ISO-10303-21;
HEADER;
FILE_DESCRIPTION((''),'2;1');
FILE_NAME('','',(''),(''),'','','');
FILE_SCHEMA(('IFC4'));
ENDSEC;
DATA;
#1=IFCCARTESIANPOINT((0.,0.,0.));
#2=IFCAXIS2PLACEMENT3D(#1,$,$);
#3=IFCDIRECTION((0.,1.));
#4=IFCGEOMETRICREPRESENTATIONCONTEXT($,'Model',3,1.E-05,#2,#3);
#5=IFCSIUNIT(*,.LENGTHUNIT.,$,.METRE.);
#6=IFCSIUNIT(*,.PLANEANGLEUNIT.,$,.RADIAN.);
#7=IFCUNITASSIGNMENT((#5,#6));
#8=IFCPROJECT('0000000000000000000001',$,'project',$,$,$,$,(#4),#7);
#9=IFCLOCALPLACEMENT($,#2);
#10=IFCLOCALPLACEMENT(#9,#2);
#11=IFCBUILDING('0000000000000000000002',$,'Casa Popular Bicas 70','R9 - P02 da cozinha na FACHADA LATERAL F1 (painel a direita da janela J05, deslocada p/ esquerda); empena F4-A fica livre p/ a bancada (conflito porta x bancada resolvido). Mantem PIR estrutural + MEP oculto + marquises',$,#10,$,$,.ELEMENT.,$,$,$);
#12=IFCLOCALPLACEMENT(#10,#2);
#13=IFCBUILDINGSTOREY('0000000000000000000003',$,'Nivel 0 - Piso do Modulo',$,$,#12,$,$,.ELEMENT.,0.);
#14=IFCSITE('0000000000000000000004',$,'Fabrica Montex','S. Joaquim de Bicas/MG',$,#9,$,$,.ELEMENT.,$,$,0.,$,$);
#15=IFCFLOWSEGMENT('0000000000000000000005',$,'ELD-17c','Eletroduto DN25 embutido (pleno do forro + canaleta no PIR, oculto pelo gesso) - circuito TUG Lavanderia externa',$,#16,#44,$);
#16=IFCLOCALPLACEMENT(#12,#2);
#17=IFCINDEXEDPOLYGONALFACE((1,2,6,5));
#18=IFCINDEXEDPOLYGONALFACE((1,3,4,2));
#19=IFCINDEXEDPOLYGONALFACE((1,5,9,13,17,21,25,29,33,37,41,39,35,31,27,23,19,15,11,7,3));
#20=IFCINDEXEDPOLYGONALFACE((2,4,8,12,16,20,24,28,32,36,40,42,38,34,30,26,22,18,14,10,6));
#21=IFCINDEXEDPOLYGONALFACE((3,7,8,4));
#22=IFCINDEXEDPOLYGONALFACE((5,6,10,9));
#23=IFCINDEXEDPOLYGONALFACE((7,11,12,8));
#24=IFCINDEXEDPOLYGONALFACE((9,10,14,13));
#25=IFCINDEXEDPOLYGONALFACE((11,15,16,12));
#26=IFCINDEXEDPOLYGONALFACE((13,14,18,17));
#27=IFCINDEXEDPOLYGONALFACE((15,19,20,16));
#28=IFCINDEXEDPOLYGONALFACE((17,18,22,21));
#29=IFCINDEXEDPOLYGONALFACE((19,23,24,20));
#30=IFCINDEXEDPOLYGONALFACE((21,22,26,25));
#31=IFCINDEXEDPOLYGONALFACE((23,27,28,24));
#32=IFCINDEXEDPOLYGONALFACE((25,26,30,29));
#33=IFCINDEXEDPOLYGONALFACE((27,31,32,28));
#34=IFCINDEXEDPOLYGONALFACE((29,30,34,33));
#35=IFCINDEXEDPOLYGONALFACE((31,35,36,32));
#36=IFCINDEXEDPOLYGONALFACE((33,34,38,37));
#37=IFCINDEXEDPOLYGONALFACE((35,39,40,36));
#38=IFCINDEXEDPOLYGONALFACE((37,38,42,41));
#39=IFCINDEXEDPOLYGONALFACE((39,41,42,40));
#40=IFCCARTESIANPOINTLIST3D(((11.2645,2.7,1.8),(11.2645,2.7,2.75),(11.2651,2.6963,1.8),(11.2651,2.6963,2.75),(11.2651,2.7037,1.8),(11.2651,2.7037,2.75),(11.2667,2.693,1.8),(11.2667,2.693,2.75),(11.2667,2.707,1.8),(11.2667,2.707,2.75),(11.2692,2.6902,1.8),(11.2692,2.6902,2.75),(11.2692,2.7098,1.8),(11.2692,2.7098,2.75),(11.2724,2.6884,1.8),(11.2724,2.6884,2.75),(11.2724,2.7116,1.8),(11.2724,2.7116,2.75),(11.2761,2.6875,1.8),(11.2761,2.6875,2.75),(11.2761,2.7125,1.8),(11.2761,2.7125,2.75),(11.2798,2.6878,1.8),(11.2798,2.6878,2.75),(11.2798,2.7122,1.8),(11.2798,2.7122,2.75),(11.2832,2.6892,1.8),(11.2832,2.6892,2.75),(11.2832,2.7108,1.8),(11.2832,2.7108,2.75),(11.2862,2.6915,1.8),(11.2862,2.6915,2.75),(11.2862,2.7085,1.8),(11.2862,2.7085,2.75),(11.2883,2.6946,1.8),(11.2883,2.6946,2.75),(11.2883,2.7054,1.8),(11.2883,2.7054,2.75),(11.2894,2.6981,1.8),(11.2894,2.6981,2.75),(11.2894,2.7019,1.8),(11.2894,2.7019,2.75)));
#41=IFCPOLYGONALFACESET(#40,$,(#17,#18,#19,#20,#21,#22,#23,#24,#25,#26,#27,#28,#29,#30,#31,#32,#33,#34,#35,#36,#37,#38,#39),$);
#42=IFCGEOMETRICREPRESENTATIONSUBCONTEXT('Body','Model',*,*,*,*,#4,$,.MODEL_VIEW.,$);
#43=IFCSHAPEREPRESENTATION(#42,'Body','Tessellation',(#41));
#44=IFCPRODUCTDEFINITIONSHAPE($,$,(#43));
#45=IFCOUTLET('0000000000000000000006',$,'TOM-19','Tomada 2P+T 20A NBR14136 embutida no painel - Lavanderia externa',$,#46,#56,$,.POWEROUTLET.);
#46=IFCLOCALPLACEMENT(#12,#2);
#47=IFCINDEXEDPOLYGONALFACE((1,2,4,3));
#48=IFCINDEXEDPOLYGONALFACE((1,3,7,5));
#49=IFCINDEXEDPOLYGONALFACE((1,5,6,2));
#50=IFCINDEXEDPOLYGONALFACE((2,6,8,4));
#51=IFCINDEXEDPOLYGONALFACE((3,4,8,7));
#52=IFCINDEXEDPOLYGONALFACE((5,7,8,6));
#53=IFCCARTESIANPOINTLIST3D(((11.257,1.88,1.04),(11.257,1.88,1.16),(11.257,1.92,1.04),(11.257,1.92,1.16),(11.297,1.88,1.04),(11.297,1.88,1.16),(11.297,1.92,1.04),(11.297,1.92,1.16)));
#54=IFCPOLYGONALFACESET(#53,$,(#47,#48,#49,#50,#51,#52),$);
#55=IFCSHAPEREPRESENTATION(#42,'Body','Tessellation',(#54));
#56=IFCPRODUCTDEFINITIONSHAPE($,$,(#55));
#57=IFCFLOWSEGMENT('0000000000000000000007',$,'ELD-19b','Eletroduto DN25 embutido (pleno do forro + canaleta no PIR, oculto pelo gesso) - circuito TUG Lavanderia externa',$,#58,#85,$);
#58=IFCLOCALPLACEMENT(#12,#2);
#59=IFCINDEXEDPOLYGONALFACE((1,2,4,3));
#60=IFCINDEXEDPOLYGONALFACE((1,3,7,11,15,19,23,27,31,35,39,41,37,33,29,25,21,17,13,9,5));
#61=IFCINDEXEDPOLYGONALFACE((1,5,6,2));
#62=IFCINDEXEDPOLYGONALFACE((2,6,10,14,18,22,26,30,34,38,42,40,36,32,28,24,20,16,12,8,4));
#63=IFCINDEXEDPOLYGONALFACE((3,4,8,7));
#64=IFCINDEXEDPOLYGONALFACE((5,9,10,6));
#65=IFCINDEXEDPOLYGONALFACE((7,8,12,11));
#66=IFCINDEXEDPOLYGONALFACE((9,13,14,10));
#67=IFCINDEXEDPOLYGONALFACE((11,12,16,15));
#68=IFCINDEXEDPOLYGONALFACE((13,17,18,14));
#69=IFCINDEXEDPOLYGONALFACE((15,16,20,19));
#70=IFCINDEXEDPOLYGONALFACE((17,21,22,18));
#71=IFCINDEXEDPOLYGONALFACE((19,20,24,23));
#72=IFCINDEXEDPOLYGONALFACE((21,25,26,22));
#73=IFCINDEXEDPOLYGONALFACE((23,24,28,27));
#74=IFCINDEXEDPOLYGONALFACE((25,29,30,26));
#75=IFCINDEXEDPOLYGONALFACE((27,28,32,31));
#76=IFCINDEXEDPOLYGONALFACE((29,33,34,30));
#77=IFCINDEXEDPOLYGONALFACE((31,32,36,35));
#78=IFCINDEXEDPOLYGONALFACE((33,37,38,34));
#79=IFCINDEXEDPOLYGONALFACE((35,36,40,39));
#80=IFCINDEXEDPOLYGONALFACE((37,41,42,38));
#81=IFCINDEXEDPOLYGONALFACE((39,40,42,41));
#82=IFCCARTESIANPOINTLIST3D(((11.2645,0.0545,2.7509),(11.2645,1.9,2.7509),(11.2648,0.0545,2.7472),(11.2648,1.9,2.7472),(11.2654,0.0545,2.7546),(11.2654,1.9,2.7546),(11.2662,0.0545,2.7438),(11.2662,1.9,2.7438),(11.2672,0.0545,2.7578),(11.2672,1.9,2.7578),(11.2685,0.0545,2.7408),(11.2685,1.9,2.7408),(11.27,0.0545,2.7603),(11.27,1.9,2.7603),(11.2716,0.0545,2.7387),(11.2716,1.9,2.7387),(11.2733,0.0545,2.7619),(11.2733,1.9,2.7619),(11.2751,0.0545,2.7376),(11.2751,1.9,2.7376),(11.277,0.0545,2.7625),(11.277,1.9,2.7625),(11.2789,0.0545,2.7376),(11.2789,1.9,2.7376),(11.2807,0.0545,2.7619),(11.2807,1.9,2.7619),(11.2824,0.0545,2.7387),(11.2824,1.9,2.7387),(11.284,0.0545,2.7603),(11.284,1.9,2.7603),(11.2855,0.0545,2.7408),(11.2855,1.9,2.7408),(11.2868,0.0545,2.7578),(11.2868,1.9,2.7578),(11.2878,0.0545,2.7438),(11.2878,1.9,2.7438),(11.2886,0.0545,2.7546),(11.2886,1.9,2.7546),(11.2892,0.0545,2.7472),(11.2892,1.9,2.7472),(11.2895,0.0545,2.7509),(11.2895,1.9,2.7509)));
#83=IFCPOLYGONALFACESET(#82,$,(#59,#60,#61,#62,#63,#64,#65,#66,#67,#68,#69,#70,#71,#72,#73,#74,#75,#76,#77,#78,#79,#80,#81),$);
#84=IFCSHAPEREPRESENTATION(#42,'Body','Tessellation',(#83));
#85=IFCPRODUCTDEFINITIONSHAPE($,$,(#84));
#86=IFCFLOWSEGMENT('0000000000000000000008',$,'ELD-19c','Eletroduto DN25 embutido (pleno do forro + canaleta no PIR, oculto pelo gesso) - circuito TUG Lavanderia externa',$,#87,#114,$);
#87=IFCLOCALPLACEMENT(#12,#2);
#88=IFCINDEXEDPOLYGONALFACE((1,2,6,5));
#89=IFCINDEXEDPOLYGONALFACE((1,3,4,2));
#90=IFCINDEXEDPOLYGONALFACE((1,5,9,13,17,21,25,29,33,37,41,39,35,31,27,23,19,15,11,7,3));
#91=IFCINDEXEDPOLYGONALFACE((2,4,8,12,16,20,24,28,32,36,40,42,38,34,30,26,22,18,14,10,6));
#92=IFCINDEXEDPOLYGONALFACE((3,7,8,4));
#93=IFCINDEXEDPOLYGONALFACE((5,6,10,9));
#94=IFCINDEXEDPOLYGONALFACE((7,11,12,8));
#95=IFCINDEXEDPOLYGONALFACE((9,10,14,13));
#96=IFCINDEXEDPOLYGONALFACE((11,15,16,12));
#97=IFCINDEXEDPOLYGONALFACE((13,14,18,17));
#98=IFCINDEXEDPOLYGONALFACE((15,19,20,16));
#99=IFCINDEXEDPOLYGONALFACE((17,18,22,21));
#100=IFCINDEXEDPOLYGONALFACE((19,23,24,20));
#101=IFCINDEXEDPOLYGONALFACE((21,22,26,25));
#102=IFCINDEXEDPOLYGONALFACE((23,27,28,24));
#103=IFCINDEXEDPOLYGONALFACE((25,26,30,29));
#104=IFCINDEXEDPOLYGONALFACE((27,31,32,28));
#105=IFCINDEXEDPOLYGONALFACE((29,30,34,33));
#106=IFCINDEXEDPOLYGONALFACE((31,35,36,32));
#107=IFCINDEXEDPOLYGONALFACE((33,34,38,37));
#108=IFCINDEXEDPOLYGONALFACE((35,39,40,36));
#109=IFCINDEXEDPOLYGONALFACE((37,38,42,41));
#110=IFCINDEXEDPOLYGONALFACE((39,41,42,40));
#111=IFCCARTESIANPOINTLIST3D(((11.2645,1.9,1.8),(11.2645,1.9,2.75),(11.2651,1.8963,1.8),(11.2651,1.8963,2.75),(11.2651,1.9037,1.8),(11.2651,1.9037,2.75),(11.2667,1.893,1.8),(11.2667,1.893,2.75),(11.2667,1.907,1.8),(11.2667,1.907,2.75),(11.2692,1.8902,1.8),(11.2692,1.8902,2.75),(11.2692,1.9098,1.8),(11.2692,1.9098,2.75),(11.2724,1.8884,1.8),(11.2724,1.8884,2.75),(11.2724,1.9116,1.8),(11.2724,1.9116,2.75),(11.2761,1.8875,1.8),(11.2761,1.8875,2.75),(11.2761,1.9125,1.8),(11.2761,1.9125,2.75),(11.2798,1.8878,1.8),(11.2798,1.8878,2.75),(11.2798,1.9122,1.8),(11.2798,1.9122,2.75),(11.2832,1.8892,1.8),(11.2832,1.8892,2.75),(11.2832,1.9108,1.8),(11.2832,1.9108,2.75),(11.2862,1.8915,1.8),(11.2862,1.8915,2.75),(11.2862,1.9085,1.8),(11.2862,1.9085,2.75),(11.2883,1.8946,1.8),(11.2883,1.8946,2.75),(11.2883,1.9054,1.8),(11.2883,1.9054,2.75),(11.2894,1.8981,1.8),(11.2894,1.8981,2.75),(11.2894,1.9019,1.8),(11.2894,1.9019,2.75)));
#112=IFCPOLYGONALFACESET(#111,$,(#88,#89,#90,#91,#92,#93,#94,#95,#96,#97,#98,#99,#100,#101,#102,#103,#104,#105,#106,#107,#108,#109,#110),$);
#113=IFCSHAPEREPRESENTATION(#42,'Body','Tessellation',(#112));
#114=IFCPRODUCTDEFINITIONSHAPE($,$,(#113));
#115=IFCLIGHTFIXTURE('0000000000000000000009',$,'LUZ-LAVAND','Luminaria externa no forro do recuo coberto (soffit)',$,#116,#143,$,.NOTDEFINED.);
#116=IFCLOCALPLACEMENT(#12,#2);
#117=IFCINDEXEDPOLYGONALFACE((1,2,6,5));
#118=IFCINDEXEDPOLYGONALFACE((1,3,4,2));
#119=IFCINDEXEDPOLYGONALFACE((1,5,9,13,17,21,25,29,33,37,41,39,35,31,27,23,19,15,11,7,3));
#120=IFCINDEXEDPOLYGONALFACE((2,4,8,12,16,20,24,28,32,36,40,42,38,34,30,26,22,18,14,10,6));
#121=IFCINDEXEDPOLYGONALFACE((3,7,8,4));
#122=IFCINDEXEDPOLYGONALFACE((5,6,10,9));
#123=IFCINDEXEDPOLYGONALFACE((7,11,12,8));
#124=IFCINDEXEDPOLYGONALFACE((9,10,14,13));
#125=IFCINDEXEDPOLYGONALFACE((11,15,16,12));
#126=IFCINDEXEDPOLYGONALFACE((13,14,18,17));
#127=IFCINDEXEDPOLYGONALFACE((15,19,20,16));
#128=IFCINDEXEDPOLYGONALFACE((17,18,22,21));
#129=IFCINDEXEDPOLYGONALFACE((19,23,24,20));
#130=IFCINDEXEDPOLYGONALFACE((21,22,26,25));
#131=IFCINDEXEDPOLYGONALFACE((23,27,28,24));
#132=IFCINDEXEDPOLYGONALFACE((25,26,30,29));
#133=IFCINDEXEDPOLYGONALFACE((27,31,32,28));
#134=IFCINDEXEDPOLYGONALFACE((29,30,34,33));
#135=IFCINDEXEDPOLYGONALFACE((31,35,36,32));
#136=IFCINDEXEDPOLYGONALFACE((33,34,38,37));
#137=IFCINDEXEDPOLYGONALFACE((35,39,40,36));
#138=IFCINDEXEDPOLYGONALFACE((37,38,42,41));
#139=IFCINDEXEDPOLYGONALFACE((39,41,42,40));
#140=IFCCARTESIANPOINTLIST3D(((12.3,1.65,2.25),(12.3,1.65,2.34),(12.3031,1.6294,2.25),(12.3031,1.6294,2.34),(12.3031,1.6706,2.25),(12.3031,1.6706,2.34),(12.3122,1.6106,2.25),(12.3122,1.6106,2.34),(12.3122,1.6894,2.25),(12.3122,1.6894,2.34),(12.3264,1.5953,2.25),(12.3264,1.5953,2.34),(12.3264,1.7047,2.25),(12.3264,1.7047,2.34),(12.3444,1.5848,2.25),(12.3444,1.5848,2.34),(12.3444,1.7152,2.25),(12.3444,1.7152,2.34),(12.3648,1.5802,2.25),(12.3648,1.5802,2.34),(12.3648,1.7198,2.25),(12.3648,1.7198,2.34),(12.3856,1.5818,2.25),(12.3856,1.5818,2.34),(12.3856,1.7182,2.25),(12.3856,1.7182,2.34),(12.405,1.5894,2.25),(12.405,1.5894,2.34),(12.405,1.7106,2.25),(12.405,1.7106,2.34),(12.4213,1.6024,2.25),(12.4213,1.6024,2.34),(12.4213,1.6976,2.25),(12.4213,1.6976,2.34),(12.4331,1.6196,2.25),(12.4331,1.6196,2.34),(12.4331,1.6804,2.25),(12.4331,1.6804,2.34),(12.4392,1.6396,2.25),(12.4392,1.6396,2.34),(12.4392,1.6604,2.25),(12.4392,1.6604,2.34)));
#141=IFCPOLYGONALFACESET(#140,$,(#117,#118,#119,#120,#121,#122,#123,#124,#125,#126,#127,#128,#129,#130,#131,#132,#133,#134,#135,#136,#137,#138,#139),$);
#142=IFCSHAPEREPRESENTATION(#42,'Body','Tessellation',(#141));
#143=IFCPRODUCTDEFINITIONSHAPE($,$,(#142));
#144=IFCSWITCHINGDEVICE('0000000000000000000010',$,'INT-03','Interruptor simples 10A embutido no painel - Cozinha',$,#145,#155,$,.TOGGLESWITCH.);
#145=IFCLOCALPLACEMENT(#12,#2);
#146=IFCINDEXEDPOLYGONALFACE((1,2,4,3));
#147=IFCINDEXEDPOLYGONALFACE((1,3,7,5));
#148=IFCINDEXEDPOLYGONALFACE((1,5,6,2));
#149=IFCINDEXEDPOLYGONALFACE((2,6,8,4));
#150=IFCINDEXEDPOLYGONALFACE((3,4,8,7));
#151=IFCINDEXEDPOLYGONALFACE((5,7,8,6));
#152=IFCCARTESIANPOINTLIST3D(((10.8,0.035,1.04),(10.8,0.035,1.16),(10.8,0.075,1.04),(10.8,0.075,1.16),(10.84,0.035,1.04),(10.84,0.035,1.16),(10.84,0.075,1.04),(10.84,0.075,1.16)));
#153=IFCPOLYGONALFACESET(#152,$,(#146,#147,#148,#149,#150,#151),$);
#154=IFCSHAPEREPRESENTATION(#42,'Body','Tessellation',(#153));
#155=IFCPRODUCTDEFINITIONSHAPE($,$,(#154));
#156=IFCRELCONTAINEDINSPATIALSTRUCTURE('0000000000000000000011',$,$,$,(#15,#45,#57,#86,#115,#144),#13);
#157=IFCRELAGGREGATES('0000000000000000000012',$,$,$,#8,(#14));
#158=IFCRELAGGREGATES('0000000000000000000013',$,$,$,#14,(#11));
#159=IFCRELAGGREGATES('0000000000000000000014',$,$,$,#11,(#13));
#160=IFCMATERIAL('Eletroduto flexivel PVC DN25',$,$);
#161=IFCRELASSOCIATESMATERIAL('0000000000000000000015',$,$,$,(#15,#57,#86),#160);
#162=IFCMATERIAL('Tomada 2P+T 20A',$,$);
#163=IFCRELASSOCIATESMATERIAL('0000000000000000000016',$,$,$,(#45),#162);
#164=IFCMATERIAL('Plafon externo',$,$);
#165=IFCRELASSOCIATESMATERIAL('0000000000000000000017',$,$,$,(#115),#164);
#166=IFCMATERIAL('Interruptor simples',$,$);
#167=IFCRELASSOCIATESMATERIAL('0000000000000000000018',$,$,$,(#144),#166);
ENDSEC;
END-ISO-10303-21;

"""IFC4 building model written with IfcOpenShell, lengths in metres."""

from ifc_helpers import new_model, si_unit, direction, frame, frame_2d, origin, origin_2d, place, context, subcontext, project, spatial, rectangle, circle, extrude, material, element, save


model = new_model("IFC4")

# Units and contexts
model_context = context("Model", 3, precision=1e-05, world=origin(), true_north=direction((0.0, 1.0)))
body_context = subcontext(model_context, "Body", "Model", "MODEL_VIEW")
ifc_project = project(units=[si_unit("LENGTHUNIT", "METRE"), si_unit("PLANEANGLEUNIT", "RADIAN")], contexts=[model_context])

# Site, building, storey
site_placement = place(None, origin())
site = spatial("IfcSite", under=ifc_project, at=site_placement, Name="Fabrica Montex", Description="S. Joaquim de Bicas/MG", CompositionType="ELEMENT", RefElevation=0.0)
building_placement = place(site_placement, origin())
building = spatial("IfcBuilding", under=site, at=building_placement, Name="Casa Popular Bicas 70", Description="R9 - P02 da cozinha na FACHADA LATERAL F1 (painel a direita da janela J05, deslocada p/ esquerda); empena F4-A fica livre p/ a bancada (conflito porta x bancada resolvido). Mantem PIR estrutural + MEP oculto + marquises", CompositionType="ELEMENT")
storey_placement = place(building_placement, origin())
storey = spatial("IfcBuildingStorey", under=building, at=storey_placement, Name="Nivel 0 - Piso do Modulo", CompositionType="ELEMENT", Elevation=0.0)

# Shared definitions
ifc_material_1 = material(Name="Eletroduto flexivel PVC DN25")

# Flow segment
flow_segment_1_placement = place(None, frame((11.277, 2.7, 2.75), z_axis=(0.0, 0.0, -1.0), x_axis=(-1.0, 0.0, 0.0)))
element("IfcFlowSegment", 1, at=flow_segment_1_placement, inside=storey, material=ifc_material_1, Name="ELD-17c", Description="Eletroduto DN25 embutido (pleno do forro + canaleta no PIR, oculto pelo gesso) - circuito TUG Lavanderia externa", context=body_context, shape_type="SweptSolid", body=[
    extrude(circle(Radius=0.0125, at=origin_2d()), origin(), (0.0, 0.0, 1.0), 0.95),
])

# Outlet
ifc_material_2 = material(Name="Tomada 2P+T 20A")
outlet_1_placement = place(None, frame((11.297, 1.92, 1.04), z_axis=(0.0, 0.0, 1.0), x_axis=(-1.0, 0.0, 0.0)))
element("IfcOutlet", 2, at=outlet_1_placement, inside=storey, material=ifc_material_2, Name="TOM-19", Description="Tomada 2P+T 20A NBR14136 embutida no painel - Lavanderia externa", PredefinedType="POWEROUTLET", context=body_context, shape_type="SweptSolid", body=[
    extrude(rectangle(XDim=0.04, YDim=0.04, at=frame_2d((0.02, 0.02))), origin(), (0.0, 0.0, 1.0), 0.12),
])

# Flow segments
flow_segment_2_placement = place(None, frame((11.277, 0.0545, 2.75), z_axis=(0.0, 1.0, 0.0), x_axis=(0.0, 0.0, 1.0)))
element("IfcFlowSegment", 3, at=flow_segment_2_placement, inside=storey, material=ifc_material_1, Name="ELD-19b", Description="Eletroduto DN25 embutido (pleno do forro + canaleta no PIR, oculto pelo gesso) - circuito TUG Lavanderia externa", context=body_context, shape_type="SweptSolid", body=[
    extrude(circle(Radius=0.0125, at=origin_2d()), origin(), (0.0, 0.0, 1.0), 1.8455),
])
flow_segment_3_placement = place(None, frame((11.277, 1.9, 2.75), z_axis=(0.0, 0.0, -1.0), x_axis=(-1.0, 0.0, 0.0)))
element("IfcFlowSegment", 4, at=flow_segment_3_placement, inside=storey, material=ifc_material_1, Name="ELD-19c", Description="Eletroduto DN25 embutido (pleno do forro + canaleta no PIR, oculto pelo gesso) - circuito TUG Lavanderia externa", context=body_context, shape_type="SweptSolid", body=[
    extrude(circle(Radius=0.0125, at=origin_2d()), origin(), (0.0, 0.0, 1.0), 0.95),
])

# Light fixture
ifc_material_3 = material(Name="Plafon externo")
light_fixture_placement = place(None, frame((12.37, 1.65, 2.25), z_axis=(0.0, 0.0, 1.0), x_axis=(-1.0, 0.0, 0.0)))
element("IfcLightFixture", 5, at=light_fixture_placement, inside=storey, material=ifc_material_3, Name="LUZ-LAVAND", Description="Luminaria externa no forro do recuo coberto (soffit)", PredefinedType="NOTDEFINED", context=body_context, shape_type="SweptSolid", body=[
    extrude(circle(Radius=0.07, at=origin_2d()), origin(), (0.0, 0.0, 1.0), 0.09),
])

# Switching device
ifc_material_4 = material(Name="Interruptor simples")
switching_device_placement = place(None, frame((10.84, 0.075, 1.04), z_axis=(0.0, 0.0, 1.0), x_axis=(-1.0, 0.0, 0.0)))
element("IfcSwitchingDevice", 6, at=switching_device_placement, inside=storey, material=ifc_material_4, Name="INT-03", Description="Interruptor simples 10A embutido no painel - Cozinha", PredefinedType="TOGGLESWITCH", context=body_context, shape_type="SweptSolid", body=[
    extrude(rectangle(XDim=0.04, YDim=0.04, at=frame_2d((0.02, 0.02))), origin(), (0.0, 0.0, 1.0), 0.12),
])

save(model, "model.ifc")
